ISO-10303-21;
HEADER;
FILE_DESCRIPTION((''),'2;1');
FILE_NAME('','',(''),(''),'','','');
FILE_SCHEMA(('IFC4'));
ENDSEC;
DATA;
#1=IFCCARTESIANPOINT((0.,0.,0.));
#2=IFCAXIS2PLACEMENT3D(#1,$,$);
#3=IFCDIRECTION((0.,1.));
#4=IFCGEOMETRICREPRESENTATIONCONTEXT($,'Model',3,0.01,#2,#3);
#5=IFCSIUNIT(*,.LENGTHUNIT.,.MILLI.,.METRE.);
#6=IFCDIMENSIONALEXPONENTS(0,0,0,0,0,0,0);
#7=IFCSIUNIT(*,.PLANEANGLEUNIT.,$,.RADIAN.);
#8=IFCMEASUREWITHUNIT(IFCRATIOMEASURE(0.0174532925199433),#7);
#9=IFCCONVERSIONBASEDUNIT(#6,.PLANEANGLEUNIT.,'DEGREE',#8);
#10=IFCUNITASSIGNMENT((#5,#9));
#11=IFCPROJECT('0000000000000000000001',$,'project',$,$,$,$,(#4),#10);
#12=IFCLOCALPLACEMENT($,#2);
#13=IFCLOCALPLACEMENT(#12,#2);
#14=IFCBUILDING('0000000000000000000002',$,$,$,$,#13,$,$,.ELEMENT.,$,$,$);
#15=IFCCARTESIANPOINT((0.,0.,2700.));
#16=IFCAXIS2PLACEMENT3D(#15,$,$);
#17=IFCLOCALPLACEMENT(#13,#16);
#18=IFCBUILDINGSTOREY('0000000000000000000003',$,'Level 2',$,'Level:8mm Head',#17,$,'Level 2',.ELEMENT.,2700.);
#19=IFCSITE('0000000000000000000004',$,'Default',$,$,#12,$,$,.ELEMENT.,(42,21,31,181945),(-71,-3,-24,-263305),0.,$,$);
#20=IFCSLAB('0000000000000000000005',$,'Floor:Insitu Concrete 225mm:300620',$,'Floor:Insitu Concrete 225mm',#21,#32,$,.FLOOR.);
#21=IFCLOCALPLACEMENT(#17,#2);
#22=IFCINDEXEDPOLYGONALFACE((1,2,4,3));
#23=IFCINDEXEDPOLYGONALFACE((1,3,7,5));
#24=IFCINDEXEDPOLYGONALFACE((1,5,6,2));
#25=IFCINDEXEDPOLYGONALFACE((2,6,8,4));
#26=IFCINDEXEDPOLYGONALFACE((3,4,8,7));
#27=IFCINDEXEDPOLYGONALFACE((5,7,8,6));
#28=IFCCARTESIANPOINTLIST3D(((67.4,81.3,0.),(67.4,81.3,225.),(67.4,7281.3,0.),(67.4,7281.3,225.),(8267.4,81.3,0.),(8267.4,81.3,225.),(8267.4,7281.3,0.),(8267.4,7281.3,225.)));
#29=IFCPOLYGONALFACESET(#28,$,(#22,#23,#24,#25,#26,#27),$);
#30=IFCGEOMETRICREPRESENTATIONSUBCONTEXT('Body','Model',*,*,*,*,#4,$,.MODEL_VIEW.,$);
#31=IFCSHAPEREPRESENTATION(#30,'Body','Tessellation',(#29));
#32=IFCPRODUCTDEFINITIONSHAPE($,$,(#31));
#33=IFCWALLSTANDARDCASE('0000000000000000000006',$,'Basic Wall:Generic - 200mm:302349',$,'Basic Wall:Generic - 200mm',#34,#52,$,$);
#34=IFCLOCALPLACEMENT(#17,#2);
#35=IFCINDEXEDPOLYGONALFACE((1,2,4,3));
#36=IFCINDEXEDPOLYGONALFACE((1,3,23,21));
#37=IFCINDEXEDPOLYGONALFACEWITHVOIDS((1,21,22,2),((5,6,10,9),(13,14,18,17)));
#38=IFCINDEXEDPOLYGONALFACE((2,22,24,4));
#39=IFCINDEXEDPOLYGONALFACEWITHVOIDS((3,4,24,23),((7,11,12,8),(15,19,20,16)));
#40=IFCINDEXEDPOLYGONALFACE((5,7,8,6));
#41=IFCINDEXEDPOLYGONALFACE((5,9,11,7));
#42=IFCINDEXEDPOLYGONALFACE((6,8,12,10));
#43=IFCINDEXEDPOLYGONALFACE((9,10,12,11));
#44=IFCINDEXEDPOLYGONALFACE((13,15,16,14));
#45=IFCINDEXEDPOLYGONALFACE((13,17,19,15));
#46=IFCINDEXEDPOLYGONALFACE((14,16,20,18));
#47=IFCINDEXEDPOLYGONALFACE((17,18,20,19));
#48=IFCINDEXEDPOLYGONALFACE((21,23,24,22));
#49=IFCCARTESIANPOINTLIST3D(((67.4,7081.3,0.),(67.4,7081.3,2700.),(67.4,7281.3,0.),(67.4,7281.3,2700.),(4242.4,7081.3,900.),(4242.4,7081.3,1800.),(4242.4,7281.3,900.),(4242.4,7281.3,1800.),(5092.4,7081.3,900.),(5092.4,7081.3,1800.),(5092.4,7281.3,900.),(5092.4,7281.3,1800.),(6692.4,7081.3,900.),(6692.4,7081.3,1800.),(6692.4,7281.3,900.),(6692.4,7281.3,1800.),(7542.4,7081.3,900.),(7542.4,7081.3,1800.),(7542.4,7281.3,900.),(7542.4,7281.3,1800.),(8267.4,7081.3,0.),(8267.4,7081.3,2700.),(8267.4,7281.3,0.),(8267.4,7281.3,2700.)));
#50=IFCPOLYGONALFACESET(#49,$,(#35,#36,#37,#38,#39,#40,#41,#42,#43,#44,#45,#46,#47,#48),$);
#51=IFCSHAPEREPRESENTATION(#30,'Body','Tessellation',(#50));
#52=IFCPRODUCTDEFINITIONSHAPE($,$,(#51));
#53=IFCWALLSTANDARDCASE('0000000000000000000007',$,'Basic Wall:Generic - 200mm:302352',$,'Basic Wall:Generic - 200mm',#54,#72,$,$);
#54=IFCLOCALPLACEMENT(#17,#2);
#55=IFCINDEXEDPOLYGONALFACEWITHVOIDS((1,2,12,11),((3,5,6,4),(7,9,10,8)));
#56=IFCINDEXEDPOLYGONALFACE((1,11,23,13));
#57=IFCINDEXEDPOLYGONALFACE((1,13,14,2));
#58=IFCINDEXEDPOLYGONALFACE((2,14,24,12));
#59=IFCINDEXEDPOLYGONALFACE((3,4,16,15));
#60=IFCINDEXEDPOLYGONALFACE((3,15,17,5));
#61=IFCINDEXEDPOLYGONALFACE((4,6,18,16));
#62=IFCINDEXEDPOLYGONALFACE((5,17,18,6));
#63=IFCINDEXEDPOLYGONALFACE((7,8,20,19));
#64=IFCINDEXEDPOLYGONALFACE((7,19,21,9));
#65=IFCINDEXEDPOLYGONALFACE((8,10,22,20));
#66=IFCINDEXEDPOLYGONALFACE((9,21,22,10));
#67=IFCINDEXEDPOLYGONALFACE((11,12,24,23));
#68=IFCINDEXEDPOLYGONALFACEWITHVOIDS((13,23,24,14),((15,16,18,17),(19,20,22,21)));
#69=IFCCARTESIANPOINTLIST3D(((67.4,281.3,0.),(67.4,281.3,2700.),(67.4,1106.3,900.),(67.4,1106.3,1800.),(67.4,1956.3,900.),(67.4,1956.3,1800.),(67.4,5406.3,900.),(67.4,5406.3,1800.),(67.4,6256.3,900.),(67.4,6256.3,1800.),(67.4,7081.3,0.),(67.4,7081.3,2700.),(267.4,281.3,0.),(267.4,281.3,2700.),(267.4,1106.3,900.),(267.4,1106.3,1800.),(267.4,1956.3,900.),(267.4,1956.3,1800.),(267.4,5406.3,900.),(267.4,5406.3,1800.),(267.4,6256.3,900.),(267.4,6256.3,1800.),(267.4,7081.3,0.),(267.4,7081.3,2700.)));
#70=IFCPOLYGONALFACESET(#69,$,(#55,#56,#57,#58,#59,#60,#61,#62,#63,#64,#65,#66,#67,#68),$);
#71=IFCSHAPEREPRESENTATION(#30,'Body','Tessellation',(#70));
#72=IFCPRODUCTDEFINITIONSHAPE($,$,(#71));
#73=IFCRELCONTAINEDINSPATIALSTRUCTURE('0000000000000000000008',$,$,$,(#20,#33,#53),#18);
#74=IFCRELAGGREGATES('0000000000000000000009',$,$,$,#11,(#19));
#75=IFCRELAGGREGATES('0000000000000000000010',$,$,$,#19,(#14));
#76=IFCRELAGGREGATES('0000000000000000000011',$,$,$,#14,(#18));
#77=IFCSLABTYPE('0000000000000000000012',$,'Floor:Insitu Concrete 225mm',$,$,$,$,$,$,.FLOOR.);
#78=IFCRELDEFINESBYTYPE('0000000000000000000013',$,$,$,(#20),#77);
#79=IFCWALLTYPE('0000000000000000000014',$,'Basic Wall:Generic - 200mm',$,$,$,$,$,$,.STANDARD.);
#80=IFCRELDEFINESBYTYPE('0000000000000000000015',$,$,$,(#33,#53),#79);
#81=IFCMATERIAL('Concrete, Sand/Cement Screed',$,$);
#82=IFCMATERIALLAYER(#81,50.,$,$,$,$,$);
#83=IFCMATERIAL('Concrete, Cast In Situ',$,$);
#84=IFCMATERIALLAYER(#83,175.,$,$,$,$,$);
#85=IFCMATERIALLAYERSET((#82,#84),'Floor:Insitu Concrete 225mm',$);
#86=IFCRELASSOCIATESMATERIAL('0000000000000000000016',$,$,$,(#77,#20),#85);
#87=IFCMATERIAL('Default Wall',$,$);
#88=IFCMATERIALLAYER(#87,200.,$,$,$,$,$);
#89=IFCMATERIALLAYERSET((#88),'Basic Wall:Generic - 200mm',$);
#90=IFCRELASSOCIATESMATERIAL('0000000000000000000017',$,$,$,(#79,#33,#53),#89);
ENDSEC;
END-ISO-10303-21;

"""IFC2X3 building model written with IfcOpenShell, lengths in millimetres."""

from ifc_helpers import new_model, entity, si_unit, converted_unit, direction, frame, frame_2d, origin, place, context, subcontext, project, spatial, rectangle, extrude, material, layer, layer_set, layer_usage, type_object, element, save


model = new_model("IFC2X3")

# Units and contexts
model_context = context("Model", 3, precision=0.01, world=origin(), true_north=direction((0.0, 1.0)))
body_context = subcontext(model_context, "Body", "Model", "MODEL_VIEW")
ifc_project = project(units=[si_unit("LENGTHUNIT", "METRE", prefix="MILLI"), converted_unit("PLANEANGLEUNIT", "DEGREE", entity("IfcRatioMeasure", 0.0174532925199433), si_unit("PLANEANGLEUNIT", "RADIAN"), dimensions=[0, 0, 0, 0, 0, 0, 0])], contexts=[model_context])

# Site, building, storey
site_placement = place(None, origin())
site = spatial("IfcSite", under=ifc_project, at=site_placement, Name="Default", CompositionType="ELEMENT", RefLatitude=(42, 21, 31, 181945), RefLongitude=(-71, -3, -24, -263305), RefElevation=0.0)
building_placement = place(site_placement, origin())
building = spatial("IfcBuilding", under=site, at=building_placement, CompositionType="ELEMENT")
storey_placement = place(building_placement, frame((0.0, 0.0, 2700.0)))
storey = spatial("IfcBuildingStorey", under=building, at=storey_placement, Name="Level 2", ObjectType="Level:8mm Head", LongName="Level 2", CompositionType="ELEMENT", Elevation=2700.0)

# Slab
ifc_material_1 = material(Name="Concrete, Sand/Cement Screed")
ifc_layer_1 = layer(ifc_material_1, 50.0)
ifc_material_2 = material(Name="Concrete, Cast In Situ")
ifc_layer_2 = layer(ifc_material_2, 175.0)
ifc_layer_set_1 = layer_set([ifc_layer_1, ifc_layer_2], Name="Floor:Insitu Concrete 225mm")
ifc_layer_usage_1 = layer_usage(ifc_layer_set_1, "AXIS3", "POSITIVE", 0.0)
slab_type = type_object("IfcSlabType", Name="Floor:Insitu Concrete 225mm", PredefinedType="FLOOR", material=ifc_layer_set_1)
slab_placement = place(storey_placement, origin())
element("IfcSlab", 1, at=slab_placement, inside=storey, type_object=slab_type, material=ifc_layer_usage_1, Name="Floor:Insitu Concrete 225mm:300620", ObjectType="Floor:Insitu Concrete 225mm", PredefinedType="FLOOR", context=body_context, shape_type="SweptSolid", body=[
    extrude(rectangle(XDim=7200.0, YDim=8200.0, at=frame_2d((0.0, 0.0), x_axis=(1.0, 0.0))), frame((4167.4, 3681.3, 225.0), z_axis=(0.0, 0.0, -1.0), x_axis=(0.0, 1.0, 0.0)), (0.0, 0.0, 1.0), 225.0),
])

# Walls, openings
ifc_material_3 = material(Name="Default Wall")
ifc_layer_3 = layer(ifc_material_3, 200.0)
ifc_layer_set_2 = layer_set([ifc_layer_3], Name="Basic Wall:Generic - 200mm")
ifc_layer_usage_2 = layer_usage(ifc_layer_set_2, "AXIS2", "NEGATIVE", 100.0)
wall_type = type_object("IfcWallType", Name="Basic Wall:Generic - 200mm", PredefinedType="STANDARD", material=ifc_layer_set_2)
wall_1_placement = place(storey_placement, frame((67.4, 7181.3, 0.0)))
wall_1 = element("IfcWallStandardCase", 2, at=wall_1_placement, inside=storey, type_object=wall_type, material=ifc_layer_usage_2, Name="Basic Wall:Generic - 200mm:302349", ObjectType="Basic Wall:Generic - 200mm", context=body_context, shape_type="SweptSolid", body=[
    extrude(rectangle(XDim=8200.0, YDim=200.0, at=frame_2d((4100.0, 0.0), x_axis=(-1.0, 0.0))), origin(), (0.0, 0.0, 1.0), 2700.0),
])
opening_1_placement = place(wall_1_placement, frame((5025.0, 100.0, 900.0)))
element("IfcOpeningElement", 3, at=opening_1_placement, cuts=wall_1, ObjectType="Opening", context=body_context, shape_type="SweptSolid", body=[
    extrude(rectangle(XDim=900.0, YDim=850.0, at=frame_2d((450.0, 425.0), x_axis=(-1.0, 0.0))), frame((0.0, 0.0, 0.0), z_axis=(0.0, -1.0, 0.0), x_axis=(0.0, 0.0, 1.0)), (0.0, 0.0, 1.0), 200.0),
])
opening_2_placement = place(wall_1_placement, frame((7475.0, 100.0, 900.0)))
element("IfcOpeningElement", 4, at=opening_2_placement, cuts=wall_1, ObjectType="Opening", context=body_context, shape_type="SweptSolid", body=[
    extrude(rectangle(XDim=900.0, YDim=850.0, at=frame_2d((450.0, 425.0), x_axis=(-1.0, 0.0))), frame((0.0, 0.0, 0.0), z_axis=(0.0, -1.0, 0.0), x_axis=(0.0, 0.0, 1.0)), (0.0, 0.0, 1.0), 200.0),
])
ifc_layer_usage_3 = layer_usage(ifc_layer_set_2, "AXIS2", "NEGATIVE", 100.0)
wall_2_placement = place(storey_placement, frame((167.4, 281.3, 0.0), z_axis=(0.0, 0.0, 1.0), x_axis=(0.0, 1.0, 0.0)))
wall_2 = element("IfcWallStandardCase", 5, at=wall_2_placement, inside=storey, type_object=wall_type, material=ifc_layer_usage_3, Name="Basic Wall:Generic - 200mm:302352", ObjectType="Basic Wall:Generic - 200mm", context=body_context, shape_type="SweptSolid", body=[
    extrude(rectangle(XDim=6800.0, YDim=200.0, at=frame_2d((3400.0, 0.0), x_axis=(-1.0, 0.0))), origin(), (0.0, 0.0, 1.0), 2700.0),
])
opening_3_placement = place(wall_2_placement, frame((5975.0, 100.0, 900.0)))
element("IfcOpeningElement", 6, at=opening_3_placement, cuts=wall_2, ObjectType="Opening", context=body_context, shape_type="SweptSolid", body=[
    extrude(rectangle(XDim=900.0, YDim=850.0, at=frame_2d((450.0, 425.0), x_axis=(-1.0, 0.0))), frame((0.0, 0.0, 0.0), z_axis=(0.0, -1.0, 0.0), x_axis=(0.0, 0.0, 1.0)), (0.0, 0.0, 1.0), 200.0),
])
opening_4_placement = place(wall_2_placement, frame((1675.0, 100.0, 900.0)))
element("IfcOpeningElement", 7, at=opening_4_placement, cuts=wall_2, ObjectType="Opening", context=body_context, shape_type="SweptSolid", body=[
    extrude(rectangle(XDim=900.0, YDim=850.0, at=frame_2d((450.0, 425.0), x_axis=(-1.0, 0.0))), frame((0.0, 0.0, 0.0), z_axis=(0.0, -1.0, 0.0), x_axis=(0.0, 0.0, 1.0)), (0.0, 0.0, 1.0), 200.0),
])

save(model, "model.ifc")
